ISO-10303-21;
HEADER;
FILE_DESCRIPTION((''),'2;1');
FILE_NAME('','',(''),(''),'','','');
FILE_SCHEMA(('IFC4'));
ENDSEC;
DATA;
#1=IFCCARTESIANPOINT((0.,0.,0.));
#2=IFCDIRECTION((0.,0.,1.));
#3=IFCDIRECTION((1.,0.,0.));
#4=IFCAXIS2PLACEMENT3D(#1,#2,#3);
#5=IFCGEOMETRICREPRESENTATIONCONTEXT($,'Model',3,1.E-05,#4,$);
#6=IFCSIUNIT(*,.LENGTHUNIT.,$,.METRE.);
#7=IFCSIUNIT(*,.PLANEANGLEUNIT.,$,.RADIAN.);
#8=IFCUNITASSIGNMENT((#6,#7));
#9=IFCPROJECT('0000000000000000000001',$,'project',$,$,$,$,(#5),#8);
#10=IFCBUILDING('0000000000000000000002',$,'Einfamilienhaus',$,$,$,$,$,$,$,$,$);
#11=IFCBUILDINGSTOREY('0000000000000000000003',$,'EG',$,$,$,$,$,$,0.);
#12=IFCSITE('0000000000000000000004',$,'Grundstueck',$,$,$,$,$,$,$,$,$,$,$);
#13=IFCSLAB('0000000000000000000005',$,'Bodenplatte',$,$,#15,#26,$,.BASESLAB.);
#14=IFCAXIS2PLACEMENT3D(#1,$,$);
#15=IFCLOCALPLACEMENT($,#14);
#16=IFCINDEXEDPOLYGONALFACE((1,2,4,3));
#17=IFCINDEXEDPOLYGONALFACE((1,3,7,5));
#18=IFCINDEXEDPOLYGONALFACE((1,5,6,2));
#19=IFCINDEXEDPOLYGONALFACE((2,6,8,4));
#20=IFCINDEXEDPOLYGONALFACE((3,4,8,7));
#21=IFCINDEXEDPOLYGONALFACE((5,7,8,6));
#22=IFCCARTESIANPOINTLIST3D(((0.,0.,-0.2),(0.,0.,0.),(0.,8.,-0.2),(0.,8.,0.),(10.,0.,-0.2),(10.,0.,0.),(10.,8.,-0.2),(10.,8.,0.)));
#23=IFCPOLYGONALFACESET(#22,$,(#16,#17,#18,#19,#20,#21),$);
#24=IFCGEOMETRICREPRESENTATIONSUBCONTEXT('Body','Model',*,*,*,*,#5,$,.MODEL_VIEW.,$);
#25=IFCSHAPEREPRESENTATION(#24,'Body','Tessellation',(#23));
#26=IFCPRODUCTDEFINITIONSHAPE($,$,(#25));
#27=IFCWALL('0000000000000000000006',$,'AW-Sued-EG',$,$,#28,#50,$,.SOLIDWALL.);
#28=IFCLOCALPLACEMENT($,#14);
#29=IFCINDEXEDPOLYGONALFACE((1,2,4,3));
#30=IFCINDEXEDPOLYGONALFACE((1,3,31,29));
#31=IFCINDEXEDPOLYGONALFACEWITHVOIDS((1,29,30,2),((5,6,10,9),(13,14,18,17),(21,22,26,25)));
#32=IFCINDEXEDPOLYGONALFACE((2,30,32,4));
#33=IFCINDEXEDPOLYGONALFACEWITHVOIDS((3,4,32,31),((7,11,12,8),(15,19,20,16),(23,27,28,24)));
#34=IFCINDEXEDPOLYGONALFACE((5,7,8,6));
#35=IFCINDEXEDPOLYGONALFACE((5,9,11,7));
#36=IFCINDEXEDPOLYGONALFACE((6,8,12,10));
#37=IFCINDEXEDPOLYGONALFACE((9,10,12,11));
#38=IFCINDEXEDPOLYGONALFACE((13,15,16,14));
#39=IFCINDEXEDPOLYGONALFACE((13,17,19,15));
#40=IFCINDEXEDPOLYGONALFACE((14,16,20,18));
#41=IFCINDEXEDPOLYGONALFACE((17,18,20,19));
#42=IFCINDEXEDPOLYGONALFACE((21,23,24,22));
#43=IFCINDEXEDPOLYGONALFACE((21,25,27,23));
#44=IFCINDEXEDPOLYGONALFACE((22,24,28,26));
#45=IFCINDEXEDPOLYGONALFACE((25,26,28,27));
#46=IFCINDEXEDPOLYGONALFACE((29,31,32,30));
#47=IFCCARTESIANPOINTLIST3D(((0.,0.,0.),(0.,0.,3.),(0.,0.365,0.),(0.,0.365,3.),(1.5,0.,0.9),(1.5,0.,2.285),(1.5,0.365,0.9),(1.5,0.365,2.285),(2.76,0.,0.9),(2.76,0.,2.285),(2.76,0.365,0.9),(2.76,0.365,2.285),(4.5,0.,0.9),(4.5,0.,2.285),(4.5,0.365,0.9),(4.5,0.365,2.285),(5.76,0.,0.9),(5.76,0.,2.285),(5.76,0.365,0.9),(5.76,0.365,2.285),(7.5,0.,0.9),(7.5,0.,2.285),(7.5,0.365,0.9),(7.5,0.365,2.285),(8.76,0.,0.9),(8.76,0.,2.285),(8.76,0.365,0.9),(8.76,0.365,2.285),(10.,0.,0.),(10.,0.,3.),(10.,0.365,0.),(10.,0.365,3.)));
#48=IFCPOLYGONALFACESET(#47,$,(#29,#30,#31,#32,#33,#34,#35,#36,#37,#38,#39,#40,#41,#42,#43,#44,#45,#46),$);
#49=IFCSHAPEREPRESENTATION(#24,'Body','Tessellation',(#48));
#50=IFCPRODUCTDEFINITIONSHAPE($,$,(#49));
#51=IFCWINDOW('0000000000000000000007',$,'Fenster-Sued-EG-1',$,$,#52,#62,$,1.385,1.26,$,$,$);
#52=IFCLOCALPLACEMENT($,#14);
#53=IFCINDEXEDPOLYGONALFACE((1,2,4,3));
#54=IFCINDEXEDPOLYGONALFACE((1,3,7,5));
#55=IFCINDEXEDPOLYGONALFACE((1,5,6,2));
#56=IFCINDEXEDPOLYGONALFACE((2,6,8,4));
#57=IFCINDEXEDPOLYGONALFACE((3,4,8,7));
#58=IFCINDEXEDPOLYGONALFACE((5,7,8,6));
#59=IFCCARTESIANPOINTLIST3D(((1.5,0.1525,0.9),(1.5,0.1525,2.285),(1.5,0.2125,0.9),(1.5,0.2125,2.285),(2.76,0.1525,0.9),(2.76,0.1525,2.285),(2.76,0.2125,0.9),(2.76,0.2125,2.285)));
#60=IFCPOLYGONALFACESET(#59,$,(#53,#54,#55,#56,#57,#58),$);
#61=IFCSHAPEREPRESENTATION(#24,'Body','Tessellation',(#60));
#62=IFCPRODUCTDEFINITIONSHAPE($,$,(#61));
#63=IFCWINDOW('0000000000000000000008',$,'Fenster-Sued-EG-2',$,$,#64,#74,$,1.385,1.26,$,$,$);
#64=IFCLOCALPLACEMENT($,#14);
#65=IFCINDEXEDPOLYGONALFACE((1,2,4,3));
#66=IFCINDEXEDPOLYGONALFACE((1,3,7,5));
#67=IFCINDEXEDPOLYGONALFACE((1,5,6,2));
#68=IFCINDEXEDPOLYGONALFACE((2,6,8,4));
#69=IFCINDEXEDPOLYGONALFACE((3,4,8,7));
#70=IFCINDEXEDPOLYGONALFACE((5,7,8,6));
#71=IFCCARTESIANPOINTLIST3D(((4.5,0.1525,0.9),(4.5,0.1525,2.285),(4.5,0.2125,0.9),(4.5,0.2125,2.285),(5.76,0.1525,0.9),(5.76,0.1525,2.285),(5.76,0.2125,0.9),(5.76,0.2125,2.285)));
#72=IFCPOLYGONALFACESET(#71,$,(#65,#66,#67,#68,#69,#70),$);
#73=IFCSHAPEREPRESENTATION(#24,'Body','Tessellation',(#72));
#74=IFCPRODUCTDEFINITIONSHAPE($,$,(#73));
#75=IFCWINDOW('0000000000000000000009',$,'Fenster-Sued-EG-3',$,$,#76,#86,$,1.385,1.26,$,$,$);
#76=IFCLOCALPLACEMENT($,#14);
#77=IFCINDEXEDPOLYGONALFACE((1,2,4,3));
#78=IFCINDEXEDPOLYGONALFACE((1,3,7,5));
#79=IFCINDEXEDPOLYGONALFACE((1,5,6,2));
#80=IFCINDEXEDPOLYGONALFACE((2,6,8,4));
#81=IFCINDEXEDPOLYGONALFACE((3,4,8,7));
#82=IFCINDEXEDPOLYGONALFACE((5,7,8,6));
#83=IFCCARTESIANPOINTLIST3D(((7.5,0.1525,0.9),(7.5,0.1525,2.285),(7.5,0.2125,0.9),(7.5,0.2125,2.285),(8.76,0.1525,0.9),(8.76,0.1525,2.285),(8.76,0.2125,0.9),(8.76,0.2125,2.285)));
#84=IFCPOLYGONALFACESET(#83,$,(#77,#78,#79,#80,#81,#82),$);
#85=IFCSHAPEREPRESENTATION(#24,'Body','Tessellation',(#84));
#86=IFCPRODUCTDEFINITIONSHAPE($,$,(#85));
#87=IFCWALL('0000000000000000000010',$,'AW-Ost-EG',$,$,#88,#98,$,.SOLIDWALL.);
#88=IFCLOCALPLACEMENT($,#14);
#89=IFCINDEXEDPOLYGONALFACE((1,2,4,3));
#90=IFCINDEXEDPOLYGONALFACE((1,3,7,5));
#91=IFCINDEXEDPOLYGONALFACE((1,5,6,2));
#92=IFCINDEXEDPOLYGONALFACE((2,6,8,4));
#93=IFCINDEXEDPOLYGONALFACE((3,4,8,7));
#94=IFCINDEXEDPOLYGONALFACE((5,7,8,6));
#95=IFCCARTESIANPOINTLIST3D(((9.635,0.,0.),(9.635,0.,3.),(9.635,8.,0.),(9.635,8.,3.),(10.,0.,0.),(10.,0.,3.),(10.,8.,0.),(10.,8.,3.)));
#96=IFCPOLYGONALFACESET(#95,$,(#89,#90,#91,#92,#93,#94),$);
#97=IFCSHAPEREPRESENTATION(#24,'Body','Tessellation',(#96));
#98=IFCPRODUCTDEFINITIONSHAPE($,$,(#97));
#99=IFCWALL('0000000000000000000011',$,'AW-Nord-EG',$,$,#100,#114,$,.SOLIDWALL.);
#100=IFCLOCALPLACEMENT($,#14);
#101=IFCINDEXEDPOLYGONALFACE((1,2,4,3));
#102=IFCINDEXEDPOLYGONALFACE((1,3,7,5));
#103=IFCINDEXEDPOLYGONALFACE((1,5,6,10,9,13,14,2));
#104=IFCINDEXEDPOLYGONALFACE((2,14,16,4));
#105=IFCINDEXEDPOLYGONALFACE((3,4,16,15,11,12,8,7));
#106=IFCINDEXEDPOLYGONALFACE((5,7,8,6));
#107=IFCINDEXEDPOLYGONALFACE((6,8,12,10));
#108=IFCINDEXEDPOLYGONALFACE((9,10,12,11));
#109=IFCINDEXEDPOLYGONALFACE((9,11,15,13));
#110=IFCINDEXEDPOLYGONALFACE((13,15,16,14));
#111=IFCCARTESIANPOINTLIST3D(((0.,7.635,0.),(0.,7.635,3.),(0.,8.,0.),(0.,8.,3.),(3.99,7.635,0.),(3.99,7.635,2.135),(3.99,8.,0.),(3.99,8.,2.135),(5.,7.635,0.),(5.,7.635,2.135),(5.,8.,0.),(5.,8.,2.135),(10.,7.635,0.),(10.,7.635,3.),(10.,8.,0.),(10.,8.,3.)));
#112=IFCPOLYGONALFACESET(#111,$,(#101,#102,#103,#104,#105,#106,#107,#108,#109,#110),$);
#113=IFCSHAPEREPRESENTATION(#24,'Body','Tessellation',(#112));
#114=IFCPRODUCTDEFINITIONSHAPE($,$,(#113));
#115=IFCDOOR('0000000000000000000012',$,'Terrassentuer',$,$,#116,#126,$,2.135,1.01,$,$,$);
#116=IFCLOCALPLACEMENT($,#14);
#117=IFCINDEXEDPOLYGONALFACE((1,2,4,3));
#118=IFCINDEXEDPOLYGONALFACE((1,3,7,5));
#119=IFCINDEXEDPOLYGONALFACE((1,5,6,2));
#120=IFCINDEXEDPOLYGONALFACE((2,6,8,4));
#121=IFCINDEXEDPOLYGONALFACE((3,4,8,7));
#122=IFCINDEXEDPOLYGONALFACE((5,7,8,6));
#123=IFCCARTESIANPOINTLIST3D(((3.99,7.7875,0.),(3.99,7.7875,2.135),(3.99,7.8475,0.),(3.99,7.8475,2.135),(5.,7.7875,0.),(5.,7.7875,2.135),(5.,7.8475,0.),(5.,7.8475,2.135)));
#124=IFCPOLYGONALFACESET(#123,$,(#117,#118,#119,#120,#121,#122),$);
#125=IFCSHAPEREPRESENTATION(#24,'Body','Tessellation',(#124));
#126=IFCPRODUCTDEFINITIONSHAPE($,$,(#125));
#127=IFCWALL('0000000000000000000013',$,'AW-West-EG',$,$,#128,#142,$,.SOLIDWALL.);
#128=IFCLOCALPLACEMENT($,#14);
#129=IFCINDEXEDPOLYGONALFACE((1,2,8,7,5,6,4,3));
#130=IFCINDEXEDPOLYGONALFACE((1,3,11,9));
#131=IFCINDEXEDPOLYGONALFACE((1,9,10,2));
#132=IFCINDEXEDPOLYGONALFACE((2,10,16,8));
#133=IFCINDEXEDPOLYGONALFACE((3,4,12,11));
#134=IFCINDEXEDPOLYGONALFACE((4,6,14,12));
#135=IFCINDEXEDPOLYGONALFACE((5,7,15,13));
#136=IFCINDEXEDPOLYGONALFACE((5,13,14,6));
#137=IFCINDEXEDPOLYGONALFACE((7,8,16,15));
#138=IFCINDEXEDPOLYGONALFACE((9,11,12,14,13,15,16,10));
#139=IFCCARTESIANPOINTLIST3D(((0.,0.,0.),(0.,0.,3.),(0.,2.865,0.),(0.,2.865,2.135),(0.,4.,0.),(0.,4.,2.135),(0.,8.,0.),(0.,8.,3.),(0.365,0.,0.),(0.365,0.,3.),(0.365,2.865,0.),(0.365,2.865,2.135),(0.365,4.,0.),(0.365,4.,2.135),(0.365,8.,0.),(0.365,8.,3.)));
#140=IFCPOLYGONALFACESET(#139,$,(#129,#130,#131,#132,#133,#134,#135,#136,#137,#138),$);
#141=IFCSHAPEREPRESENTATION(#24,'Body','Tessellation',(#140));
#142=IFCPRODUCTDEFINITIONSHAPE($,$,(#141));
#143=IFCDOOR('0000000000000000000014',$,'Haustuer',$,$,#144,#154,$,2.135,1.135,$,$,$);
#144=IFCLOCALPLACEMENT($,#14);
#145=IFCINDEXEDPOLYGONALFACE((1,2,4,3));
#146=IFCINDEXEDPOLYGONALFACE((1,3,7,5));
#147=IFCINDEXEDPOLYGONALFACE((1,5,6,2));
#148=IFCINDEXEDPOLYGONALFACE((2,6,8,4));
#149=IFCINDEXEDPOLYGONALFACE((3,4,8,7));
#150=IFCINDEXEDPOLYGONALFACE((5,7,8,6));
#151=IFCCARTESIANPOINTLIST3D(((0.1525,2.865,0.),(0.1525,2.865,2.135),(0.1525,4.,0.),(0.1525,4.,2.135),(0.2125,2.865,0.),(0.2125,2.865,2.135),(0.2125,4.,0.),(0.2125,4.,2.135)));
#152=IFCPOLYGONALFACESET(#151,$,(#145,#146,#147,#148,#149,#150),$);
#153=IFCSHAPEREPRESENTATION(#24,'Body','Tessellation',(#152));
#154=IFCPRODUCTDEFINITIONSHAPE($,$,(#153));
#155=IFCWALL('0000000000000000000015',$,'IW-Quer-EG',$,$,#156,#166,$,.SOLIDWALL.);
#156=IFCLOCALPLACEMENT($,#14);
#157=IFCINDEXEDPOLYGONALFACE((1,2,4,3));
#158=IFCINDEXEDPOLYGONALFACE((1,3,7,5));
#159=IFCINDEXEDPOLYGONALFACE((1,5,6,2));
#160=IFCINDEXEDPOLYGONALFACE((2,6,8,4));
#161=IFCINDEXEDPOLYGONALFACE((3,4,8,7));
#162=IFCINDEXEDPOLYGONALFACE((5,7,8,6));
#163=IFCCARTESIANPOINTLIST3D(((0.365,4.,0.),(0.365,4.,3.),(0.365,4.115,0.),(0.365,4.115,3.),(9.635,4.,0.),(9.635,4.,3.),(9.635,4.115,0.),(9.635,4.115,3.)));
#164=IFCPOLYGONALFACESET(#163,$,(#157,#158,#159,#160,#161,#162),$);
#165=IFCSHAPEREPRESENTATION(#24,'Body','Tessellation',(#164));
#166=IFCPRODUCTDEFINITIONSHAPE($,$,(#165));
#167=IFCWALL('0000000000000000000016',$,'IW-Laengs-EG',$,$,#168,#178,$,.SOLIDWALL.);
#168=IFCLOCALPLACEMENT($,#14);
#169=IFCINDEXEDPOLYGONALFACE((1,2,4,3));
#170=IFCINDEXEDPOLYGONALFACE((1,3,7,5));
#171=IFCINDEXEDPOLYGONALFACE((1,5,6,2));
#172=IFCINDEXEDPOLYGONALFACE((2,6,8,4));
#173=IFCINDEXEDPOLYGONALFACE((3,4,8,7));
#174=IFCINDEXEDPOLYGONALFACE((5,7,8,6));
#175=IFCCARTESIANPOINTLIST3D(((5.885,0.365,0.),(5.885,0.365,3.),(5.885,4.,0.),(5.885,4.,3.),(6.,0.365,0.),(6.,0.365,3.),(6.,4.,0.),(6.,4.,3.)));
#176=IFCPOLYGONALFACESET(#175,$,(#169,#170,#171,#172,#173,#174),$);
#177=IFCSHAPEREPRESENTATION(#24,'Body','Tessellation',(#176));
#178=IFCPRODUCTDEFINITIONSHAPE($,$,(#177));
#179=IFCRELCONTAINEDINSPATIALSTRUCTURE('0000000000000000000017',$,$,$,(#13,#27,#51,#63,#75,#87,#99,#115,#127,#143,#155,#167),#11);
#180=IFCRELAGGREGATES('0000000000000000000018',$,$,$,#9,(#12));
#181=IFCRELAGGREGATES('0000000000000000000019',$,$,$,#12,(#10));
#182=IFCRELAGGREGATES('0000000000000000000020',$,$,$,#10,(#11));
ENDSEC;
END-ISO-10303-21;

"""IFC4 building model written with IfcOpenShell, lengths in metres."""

from ifc_helpers import new_model, si_unit, frame, origin_with_axes, place, context, subcontext, project, spatial, indexed_curve, outline, extrude, element, fill, save


model = new_model("IFC4")

# Units and contexts
model_context = context("Model", 3, precision=1e-05, world=origin_with_axes())
body_context = subcontext(model_context, "Body", "Model", "MODEL_VIEW")
ifc_project = project(units=[si_unit("LENGTHUNIT", "METRE"), si_unit("PLANEANGLEUNIT", "RADIAN")], contexts=[model_context])

# Site, building, storey
site = spatial("IfcSite", under=ifc_project, Name="Grundstueck")
building = spatial("IfcBuilding", under=site, Name="Einfamilienhaus")
storey = spatial("IfcBuildingStorey", under=building, Name="EG", Elevation=0.0)

# Slab
slab_placement = place(None, frame((0.0, 0.0, -0.2), z_axis=(0.0, 0.0, 1.0), x_axis=(1.0, 0.0, 0.0)))
element("IfcSlab", 1, at=slab_placement, inside=storey, Name="Bodenplatte", PredefinedType="BASESLAB", context=body_context, shape_type="SweptSolid", body=[
    extrude(outline(indexed_curve([(0.0, 0.0), (10.0, 0.0), (10.0, 8.0), (0.0, 8.0)])), None, (0.0, 0.0, 1.0), 0.2),
])

# Wall, openings, windows
wall_1_placement = place(None, origin_with_axes())
wall_1 = element("IfcWall", 2, at=wall_1_placement, inside=storey, Name="AW-Sued-EG", PredefinedType="SOLIDWALL", context=body_context, shape_type="SweptSolid", body=[
    extrude(outline(indexed_curve([(0.0, 0.0), (0.0, 0.365), (10.0, 0.365), (10.0, 0.0), (0.0, 0.0)], self_intersect=False)), origin_with_axes(), (0.0, 0.0, 1.0), 3.0),
])
opening_1_placement = place(wall_1_placement, frame((1.5, 0.0, 0.9), z_axis=(0.0, 0.0, 1.0), x_axis=(1.0, 0.0, 0.0)))
opening_1 = element("IfcOpeningElement", 3, at=opening_1_placement, cuts=wall_1, PredefinedType="OPENING", context=body_context, shape_type="SweptSolid", body=[
    extrude(outline(indexed_curve([(0.0, 0.0), (0.0, 0.465), (1.26, 0.465), (1.26, 0.0), (0.0, 0.0)], self_intersect=False)), frame((0.0, -0.05, 0.0), z_axis=(0.0, 0.0, 1.0), x_axis=(1.0, 0.0, 0.0)), (0.0, 0.0, 1.0), 1.385),
])
opening_2_placement = place(wall_1_placement, frame((4.5, 0.0, 0.9), z_axis=(0.0, 0.0, 1.0), x_axis=(1.0, 0.0, 0.0)))
opening_2 = element("IfcOpeningElement", 4, at=opening_2_placement, cuts=wall_1, PredefinedType="OPENING", context=body_context, shape_type="SweptSolid", body=[
    extrude(outline(indexed_curve([(0.0, 0.0), (0.0, 0.465), (1.26, 0.465), (1.26, 0.0), (0.0, 0.0)], self_intersect=False)), frame((0.0, -0.05, 0.0), z_axis=(0.0, 0.0, 1.0), x_axis=(1.0, 0.0, 0.0)), (0.0, 0.0, 1.0), 1.385),
])
opening_3_placement = place(wall_1_placement, frame((7.5, 0.0, 0.9), z_axis=(0.0, 0.0, 1.0), x_axis=(1.0, 0.0, 0.0)))
opening_3 = element("IfcOpeningElement", 5, at=opening_3_placement, cuts=wall_1, PredefinedType="OPENING", context=body_context, shape_type="SweptSolid", body=[
    extrude(outline(indexed_curve([(0.0, 0.0), (0.0, 0.465), (1.26, 0.465), (1.26, 0.0), (0.0, 0.0)], self_intersect=False)), frame((0.0, -0.05, 0.0), z_axis=(0.0, 0.0, 1.0), x_axis=(1.0, 0.0, 0.0)), (0.0, 0.0, 1.0), 1.385),
])
window_1_placement = place(opening_1_placement, origin_with_axes())
window_1 = element("IfcWindow", 6, at=window_1_placement, inside=storey, Name="Fenster-Sued-EG-1", OverallHeight=1.385, OverallWidth=1.26, context=body_context, shape_type="SweptSolid", body=[
    extrude(outline(indexed_curve([(0.0, 0.0), (0.0, 0.06), (1.26, 0.06), (1.26, 0.0), (0.0, 0.0)], self_intersect=False)), frame((0.0, 0.1525, 0.0), z_axis=(0.0, 0.0, 1.0), x_axis=(1.0, 0.0, 0.0)), (0.0, 0.0, 1.0), 1.385),
])
fill(opening_1, window_1)
window_2_placement = place(opening_2_placement, origin_with_axes())
window_2 = element("IfcWindow", 7, at=window_2_placement, inside=storey, Name="Fenster-Sued-EG-2", OverallHeight=1.385, OverallWidth=1.26, context=body_context, shape_type="SweptSolid", body=[
    extrude(outline(indexed_curve([(0.0, 0.0), (0.0, 0.06), (1.26, 0.06), (1.26, 0.0), (0.0, 0.0)], self_intersect=False)), frame((0.0, 0.1525, 0.0), z_axis=(0.0, 0.0, 1.0), x_axis=(1.0, 0.0, 0.0)), (0.0, 0.0, 1.0), 1.385),
])
fill(opening_2, window_2)
window_3_placement = place(opening_3_placement, origin_with_axes())
window_3 = element("IfcWindow", 8, at=window_3_placement, inside=storey, Name="Fenster-Sued-EG-3", OverallHeight=1.385, OverallWidth=1.26, context=body_context, shape_type="SweptSolid", body=[
    extrude(outline(indexed_curve([(0.0, 0.0), (0.0, 0.06), (1.26, 0.06), (1.26, 0.0), (0.0, 0.0)], self_intersect=False)), frame((0.0, 0.1525, 0.0), z_axis=(0.0, 0.0, 1.0), x_axis=(1.0, 0.0, 0.0)), (0.0, 0.0, 1.0), 1.385),
])
fill(opening_3, window_3)

# Wall
wall_2_placement = place(None, frame((10.0, 0.0, 0.0), z_axis=(0.0, 0.0, 1.0), x_axis=(0.0, 1.0, 0.0)))
element("IfcWall", 9, at=wall_2_placement, inside=storey, Name="AW-Ost-EG", PredefinedType="SOLIDWALL", context=body_context, shape_type="SweptSolid", body=[
    extrude(outline(indexed_curve([(0.0, 0.0), (0.0, 0.365), (8.0, 0.365), (8.0, 0.0), (0.0, 0.0)], self_intersect=False)), origin_with_axes(), (0.0, 0.0, 1.0), 3.0),
])

# Walls, openings, doors
wall_3_placement = place(None, frame((10.0, 8.0, 0.0), z_axis=(0.0, 0.0, 1.0), x_axis=(-1.0, 0.0, 0.0)))
wall_3 = element("IfcWall", 10, at=wall_3_placement, inside=storey, Name="AW-Nord-EG", PredefinedType="SOLIDWALL", context=body_context, shape_type="SweptSolid", body=[
    extrude(outline(indexed_curve([(0.0, 0.0), (0.0, 0.365), (10.0, 0.365), (10.0, 0.0), (0.0, 0.0)], self_intersect=False)), origin_with_axes(), (0.0, 0.0, 1.0), 3.0),
])
opening_4_placement = place(wall_3_placement, frame((5.0, 0.0, 0.0), z_axis=(0.0, 0.0, 1.0), x_axis=(1.0, 0.0, 0.0)))
opening_4 = element("IfcOpeningElement", 11, at=opening_4_placement, cuts=wall_3, PredefinedType="OPENING", context=body_context, shape_type="SweptSolid", body=[
    extrude(outline(indexed_curve([(0.0, 0.0), (0.0, 0.465), (1.01, 0.465), (1.01, 0.0), (0.0, 0.0)], self_intersect=False)), frame((0.0, -0.05, 0.0), z_axis=(0.0, 0.0, 1.0), x_axis=(1.0, 0.0, 0.0)), (0.0, 0.0, 1.0), 2.135),
])
door_1_placement = place(opening_4_placement, origin_with_axes())
door_1 = element("IfcDoor", 12, at=door_1_placement, inside=storey, Name="Terrassentuer", OverallHeight=2.135, OverallWidth=1.01, context=body_context, shape_type="SweptSolid", body=[
    extrude(outline(indexed_curve([(0.0, 0.0), (0.0, 0.06), (1.01, 0.06), (1.01, 0.0), (0.0, 0.0)], self_intersect=False)), frame((0.0, 0.1525, 0.0), z_axis=(0.0, 0.0, 1.0), x_axis=(1.0, 0.0, 0.0)), (0.0, 0.0, 1.0), 2.135),
])
fill(opening_4, door_1)
wall_4_placement = place(None, frame((0.0, 8.0, 0.0), z_axis=(0.0, 0.0, 1.0), x_axis=(0.0, -1.0, 0.0)))
wall_4 = element("IfcWall", 13, at=wall_4_placement, inside=storey, Name="AW-West-EG", PredefinedType="SOLIDWALL", context=body_context, shape_type="SweptSolid", body=[
    extrude(outline(indexed_curve([(0.0, 0.0), (0.0, 0.365), (8.0, 0.365), (8.0, 0.0), (0.0, 0.0)], self_intersect=False)), origin_with_axes(), (0.0, 0.0, 1.0), 3.0),
])
opening_5_placement = place(wall_4_placement, frame((4.0, 0.0, 0.0), z_axis=(0.0, 0.0, 1.0), x_axis=(1.0, 0.0, 0.0)))
opening_5 = element("IfcOpeningElement", 14, at=opening_5_placement, cuts=wall_4, PredefinedType="OPENING", context=body_context, shape_type="SweptSolid", body=[
    extrude(outline(indexed_curve([(0.0, 0.0), (0.0, 0.465), (1.135, 0.465), (1.135, 0.0), (0.0, 0.0)], self_intersect=False)), frame((0.0, -0.05, 0.0), z_axis=(0.0, 0.0, 1.0), x_axis=(1.0, 0.0, 0.0)), (0.0, 0.0, 1.0), 2.135),
])
door_2_placement = place(opening_5_placement, origin_with_axes())
door_2 = element("IfcDoor", 15, at=door_2_placement, inside=storey, Name="Haustuer", OverallHeight=2.135, OverallWidth=1.135, context=body_context, shape_type="SweptSolid", body=[
    extrude(outline(indexed_curve([(0.0, 0.0), (0.0, 0.06), (1.135, 0.06), (1.135, 0.0), (0.0, 0.0)], self_intersect=False)), frame((0.0, 0.1525, 0.0), z_axis=(0.0, 0.0, 1.0), x_axis=(1.0, 0.0, 0.0)), (0.0, 0.0, 1.0), 2.135),
])
fill(opening_5, door_2)

# Walls
wall_5_placement = place(None, frame((0.365, 4.0, 0.0), z_axis=(0.0, 0.0, 1.0), x_axis=(1.0, 0.0, 0.0)))
element("IfcWall", 16, at=wall_5_placement, inside=storey, Name="IW-Quer-EG", PredefinedType="SOLIDWALL", context=body_context, shape_type="SweptSolid", body=[
    extrude(outline(indexed_curve([(0.0, 0.0), (0.0, 0.115), (9.27, 0.115), (9.27, 0.0), (0.0, 0.0)], self_intersect=False)), origin_with_axes(), (0.0, 0.0, 1.0), 3.0),
])
wall_6_placement = place(None, frame((6.0, 0.365, 0.0), z_axis=(0.0, 0.0, 1.0), x_axis=(0.0, 1.0, 0.0)))
element("IfcWall", 17, at=wall_6_placement, inside=storey, Name="IW-Laengs-EG", PredefinedType="SOLIDWALL", context=body_context, shape_type="SweptSolid", body=[
    extrude(outline(indexed_curve([(0.0, 0.0), (0.0, 0.115), (3.635, 0.115), (3.635, 0.0), (0.0, 0.0)], self_intersect=False)), origin_with_axes(), (0.0, 0.0, 1.0), 3.0),
])

save(model, "model.ifc")
